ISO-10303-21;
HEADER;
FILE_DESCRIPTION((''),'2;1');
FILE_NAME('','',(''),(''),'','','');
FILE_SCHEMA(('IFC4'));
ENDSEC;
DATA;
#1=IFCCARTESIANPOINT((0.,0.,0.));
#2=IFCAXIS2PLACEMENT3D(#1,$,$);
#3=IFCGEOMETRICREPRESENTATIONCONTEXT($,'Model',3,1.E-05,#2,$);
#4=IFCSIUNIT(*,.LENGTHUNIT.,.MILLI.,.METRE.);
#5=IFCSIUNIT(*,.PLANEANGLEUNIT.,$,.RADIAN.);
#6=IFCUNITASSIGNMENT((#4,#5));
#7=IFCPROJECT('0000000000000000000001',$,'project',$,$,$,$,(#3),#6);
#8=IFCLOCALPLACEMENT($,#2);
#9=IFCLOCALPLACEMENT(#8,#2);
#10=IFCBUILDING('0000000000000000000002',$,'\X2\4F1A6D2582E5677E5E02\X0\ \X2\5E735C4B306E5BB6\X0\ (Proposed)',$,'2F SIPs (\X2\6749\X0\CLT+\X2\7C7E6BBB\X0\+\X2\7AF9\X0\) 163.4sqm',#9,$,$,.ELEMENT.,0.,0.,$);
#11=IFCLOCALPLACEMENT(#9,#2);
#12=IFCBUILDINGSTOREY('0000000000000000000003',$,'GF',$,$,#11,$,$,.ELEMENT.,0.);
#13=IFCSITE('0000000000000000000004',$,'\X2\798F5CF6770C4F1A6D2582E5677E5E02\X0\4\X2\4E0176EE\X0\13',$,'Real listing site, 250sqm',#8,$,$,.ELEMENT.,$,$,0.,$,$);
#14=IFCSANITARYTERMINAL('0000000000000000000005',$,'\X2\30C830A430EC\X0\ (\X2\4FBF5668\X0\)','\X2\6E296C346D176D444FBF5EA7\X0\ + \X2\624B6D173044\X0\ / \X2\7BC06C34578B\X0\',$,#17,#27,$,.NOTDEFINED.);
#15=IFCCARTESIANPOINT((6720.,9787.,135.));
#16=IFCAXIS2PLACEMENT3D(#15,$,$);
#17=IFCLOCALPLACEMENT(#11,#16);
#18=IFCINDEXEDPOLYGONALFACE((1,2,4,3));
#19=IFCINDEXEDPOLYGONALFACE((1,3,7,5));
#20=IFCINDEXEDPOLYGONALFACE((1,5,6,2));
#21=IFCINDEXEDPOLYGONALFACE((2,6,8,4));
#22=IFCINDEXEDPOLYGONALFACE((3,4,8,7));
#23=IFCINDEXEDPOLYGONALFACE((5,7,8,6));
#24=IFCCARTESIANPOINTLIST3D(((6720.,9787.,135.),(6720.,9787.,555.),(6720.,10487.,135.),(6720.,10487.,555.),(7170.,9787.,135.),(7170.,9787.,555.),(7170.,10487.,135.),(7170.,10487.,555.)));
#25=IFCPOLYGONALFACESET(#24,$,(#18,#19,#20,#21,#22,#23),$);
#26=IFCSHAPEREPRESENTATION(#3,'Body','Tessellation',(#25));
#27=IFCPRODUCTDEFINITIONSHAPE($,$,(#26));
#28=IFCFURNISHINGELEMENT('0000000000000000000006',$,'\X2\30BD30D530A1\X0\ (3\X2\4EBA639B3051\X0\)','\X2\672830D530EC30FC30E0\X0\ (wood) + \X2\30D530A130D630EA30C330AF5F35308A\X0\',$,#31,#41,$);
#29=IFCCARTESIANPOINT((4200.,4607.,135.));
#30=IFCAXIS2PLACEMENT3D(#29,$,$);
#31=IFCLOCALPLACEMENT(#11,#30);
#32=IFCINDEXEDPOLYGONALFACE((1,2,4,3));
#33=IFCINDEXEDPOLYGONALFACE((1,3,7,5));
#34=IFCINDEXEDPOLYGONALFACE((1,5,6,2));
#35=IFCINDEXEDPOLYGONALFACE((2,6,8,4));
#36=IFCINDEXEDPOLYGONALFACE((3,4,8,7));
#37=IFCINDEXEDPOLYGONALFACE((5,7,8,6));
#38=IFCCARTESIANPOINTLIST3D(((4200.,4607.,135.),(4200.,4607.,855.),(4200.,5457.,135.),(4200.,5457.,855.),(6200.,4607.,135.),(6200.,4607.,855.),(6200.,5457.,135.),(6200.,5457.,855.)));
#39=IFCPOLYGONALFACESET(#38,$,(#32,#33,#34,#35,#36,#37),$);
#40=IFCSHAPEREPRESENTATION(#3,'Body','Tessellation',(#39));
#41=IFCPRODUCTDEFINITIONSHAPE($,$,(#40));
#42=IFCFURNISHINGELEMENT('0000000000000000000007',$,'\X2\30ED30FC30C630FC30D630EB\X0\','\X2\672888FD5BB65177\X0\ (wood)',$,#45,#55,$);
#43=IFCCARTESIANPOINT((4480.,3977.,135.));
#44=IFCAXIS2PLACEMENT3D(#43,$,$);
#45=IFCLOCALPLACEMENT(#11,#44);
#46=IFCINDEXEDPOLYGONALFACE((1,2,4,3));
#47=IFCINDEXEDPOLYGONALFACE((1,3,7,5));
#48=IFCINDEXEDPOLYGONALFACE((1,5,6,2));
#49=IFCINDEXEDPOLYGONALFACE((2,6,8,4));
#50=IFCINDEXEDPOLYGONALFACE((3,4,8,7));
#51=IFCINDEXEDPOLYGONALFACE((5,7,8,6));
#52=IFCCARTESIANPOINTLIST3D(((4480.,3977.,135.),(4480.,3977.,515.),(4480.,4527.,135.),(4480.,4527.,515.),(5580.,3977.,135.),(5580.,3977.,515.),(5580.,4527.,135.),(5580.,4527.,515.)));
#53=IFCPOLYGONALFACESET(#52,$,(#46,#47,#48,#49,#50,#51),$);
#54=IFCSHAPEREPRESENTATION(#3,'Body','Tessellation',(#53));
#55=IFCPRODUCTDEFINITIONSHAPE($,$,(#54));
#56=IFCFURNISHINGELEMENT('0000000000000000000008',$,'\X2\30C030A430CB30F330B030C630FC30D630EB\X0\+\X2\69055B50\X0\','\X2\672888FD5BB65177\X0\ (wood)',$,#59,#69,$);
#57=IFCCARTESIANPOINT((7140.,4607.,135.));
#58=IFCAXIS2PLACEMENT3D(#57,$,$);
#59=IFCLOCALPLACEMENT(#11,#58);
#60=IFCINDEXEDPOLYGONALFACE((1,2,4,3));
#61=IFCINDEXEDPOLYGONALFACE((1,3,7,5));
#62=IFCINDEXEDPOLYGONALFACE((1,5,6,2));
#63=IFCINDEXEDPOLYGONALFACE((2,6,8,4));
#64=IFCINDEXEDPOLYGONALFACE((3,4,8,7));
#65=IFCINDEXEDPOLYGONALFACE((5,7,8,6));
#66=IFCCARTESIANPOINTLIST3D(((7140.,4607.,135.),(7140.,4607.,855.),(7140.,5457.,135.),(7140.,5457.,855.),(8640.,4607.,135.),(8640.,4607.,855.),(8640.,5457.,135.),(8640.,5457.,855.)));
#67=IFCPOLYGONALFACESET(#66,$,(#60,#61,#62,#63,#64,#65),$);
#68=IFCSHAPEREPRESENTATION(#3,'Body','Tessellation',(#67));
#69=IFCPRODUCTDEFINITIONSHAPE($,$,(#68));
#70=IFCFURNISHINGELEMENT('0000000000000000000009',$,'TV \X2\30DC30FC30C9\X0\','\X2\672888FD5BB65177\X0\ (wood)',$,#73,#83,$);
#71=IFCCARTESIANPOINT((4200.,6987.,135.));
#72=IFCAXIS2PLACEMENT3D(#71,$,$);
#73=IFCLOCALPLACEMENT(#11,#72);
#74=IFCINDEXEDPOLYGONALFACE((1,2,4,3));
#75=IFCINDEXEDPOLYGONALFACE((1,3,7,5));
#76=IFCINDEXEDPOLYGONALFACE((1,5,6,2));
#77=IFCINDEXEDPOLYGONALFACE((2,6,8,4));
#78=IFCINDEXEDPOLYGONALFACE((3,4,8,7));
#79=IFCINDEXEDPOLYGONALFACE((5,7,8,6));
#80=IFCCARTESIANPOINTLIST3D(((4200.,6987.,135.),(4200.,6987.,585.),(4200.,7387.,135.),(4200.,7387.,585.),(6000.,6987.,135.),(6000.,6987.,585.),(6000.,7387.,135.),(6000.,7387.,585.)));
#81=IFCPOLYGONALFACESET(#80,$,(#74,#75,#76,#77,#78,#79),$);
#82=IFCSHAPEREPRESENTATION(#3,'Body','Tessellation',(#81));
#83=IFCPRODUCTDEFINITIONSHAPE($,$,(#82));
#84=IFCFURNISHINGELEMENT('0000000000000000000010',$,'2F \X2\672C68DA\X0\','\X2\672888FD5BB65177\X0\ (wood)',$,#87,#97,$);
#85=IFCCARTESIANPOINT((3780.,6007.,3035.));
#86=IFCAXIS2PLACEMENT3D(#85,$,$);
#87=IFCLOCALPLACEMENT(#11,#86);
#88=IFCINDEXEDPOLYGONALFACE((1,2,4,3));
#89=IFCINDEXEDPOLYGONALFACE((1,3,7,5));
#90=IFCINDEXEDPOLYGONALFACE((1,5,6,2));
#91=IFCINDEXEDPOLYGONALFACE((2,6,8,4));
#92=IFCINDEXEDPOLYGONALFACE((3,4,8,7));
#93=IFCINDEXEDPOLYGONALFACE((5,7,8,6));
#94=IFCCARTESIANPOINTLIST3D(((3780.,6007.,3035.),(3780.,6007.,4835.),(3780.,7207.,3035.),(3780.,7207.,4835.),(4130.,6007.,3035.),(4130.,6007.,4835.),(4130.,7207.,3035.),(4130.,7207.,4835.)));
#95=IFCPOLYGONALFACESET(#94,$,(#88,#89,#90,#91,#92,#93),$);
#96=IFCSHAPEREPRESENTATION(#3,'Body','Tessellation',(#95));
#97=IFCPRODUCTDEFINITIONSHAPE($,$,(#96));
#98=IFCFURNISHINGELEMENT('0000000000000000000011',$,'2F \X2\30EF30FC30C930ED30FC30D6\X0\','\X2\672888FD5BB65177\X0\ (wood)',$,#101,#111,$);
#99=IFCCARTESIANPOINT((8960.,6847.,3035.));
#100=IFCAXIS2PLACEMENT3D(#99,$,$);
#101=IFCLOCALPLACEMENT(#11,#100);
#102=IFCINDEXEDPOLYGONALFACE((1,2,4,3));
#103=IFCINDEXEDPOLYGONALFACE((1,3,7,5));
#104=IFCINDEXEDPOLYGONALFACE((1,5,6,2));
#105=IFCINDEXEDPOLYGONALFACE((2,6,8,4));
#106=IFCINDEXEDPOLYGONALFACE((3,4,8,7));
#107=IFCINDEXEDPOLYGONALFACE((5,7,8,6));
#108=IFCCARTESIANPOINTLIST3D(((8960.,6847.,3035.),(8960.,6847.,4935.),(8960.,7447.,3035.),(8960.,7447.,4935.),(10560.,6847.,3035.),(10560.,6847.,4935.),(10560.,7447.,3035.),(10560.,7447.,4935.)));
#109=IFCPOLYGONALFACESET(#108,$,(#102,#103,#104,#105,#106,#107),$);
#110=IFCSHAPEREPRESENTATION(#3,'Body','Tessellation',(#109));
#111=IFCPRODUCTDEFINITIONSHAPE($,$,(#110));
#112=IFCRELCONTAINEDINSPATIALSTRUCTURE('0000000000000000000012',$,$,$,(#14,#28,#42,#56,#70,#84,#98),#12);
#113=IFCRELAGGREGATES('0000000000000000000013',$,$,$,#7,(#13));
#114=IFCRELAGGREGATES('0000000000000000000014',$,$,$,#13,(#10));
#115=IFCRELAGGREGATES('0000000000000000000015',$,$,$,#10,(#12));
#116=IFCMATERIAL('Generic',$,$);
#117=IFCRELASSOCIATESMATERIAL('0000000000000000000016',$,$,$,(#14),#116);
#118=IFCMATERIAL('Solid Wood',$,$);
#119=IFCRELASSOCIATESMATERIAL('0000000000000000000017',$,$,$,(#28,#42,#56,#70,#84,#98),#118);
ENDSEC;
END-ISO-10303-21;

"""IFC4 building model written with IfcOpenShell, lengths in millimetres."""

from ifc_helpers import new_model, si_unit, frame, frame_2d, origin, place, context, project, spatial, rectangle, extrude, material, element, save


model = new_model("IFC4")

# Units and contexts
model_context = context("Model", 3, precision=1e-05, world=origin())
ifc_project = project(units=[si_unit("LENGTHUNIT", "METRE", prefix="MILLI"), si_unit("PLANEANGLEUNIT", "RADIAN")], contexts=[model_context])

# Site, building, storey
site_placement = place(None, origin())
site = spatial("IfcSite", under=ifc_project, at=site_placement, Name="福島県会津若松市4丁目13", ObjectType="Real listing site, 250sqm", CompositionType="ELEMENT", RefElevation=0.0)
building_placement = place(site_placement, origin())
building = spatial("IfcBuilding", under=site, at=building_placement, Name="会津若松市 平屋の家 (Proposed)", ObjectType="2F SIPs (杉CLT+籾殻+竹) 163.4sqm", CompositionType="ELEMENT", ElevationOfRefHeight=0.0, ElevationOfTerrain=0.0)
storey_placement = place(building_placement, origin())
storey = spatial("IfcBuildingStorey", under=building, at=storey_placement, Name="GF", CompositionType="ELEMENT", Elevation=0.0)

# Shared definitions
ifc_material_1 = material(Name="Generic")

# Shared definitions
ifc_material_2 = material(Name="Solid Wood")

# Sanitary terminal
sanitary_terminal_1_placement = place(storey_placement, frame((6720.0, 9787.0, 135.0)))
element("IfcSanitaryTerminal", 1, at=sanitary_terminal_1_placement, inside=storey, material=ifc_material_1, Name="トイレ (便器)", Description="温水洗浄便座 + 手洗い / 節水型", PredefinedType="NOTDEFINED", context=model_context, shape_type="SweptSolid", body=[
    extrude(rectangle(XDim=450.0, YDim=700.0, at=frame_2d((225.0, 350.0))), frame((6720.0, 9787.0, 135.0)), (0.0, 0.0, 1.0), 420.0),
])

# Furnishing elements
furnishing_1_placement = place(storey_placement, frame((4200.0, 4607.0, 135.0)))
element("IfcFurnishingElement", 2, at=furnishing_1_placement, inside=storey, material=ifc_material_2, Name="ソファ (3人掛け)", Description="木フレーム (wood) + ファブリック張り", context=model_context, shape_type="SweptSolid", body=[
    extrude(rectangle(XDim=2000.0, YDim=850.0, at=frame_2d((1000.0, 425.0))), frame((4200.0, 4607.0, 135.0)), (0.0, 0.0, 1.0), 720.0),
])
furnishing_2_placement = place(storey_placement, frame((4480.0, 3977.0, 135.0)))
element("IfcFurnishingElement", 3, at=furnishing_2_placement, inside=storey, material=ifc_material_2, Name="ローテーブル", Description="木製家具 (wood)", context=model_context, shape_type="SweptSolid", body=[
    extrude(rectangle(XDim=1100.0, YDim=550.0, at=frame_2d((550.0, 275.0))), frame((4480.0, 3977.0, 135.0)), (0.0, 0.0, 1.0), 380.0),
])
furnishing_3_placement = place(storey_placement, frame((7140.0, 4607.0, 135.0)))
element("IfcFurnishingElement", 4, at=furnishing_3_placement, inside=storey, material=ifc_material_2, Name="ダイニングテーブル+椅子", Description="木製家具 (wood)", context=model_context, shape_type="SweptSolid", body=[
    extrude(rectangle(XDim=1500.0, YDim=850.0, at=frame_2d((750.0, 425.0))), frame((7140.0, 4607.0, 135.0)), (0.0, 0.0, 1.0), 720.0),
])
furnishing_4_placement = place(storey_placement, frame((4200.0, 6987.0, 135.0)))
element("IfcFurnishingElement", 5, at=furnishing_4_placement, inside=storey, material=ifc_material_2, Name="TV ボード", Description="木製家具 (wood)", context=model_context, shape_type="SweptSolid", body=[
    extrude(rectangle(XDim=1800.0, YDim=400.0, at=frame_2d((900.0, 200.0))), frame((4200.0, 6987.0, 135.0)), (0.0, 0.0, 1.0), 450.0),
])
furnishing_5_placement = place(storey_placement, frame((3780.0, 6007.0, 3035.0)))
element("IfcFurnishingElement", 6, at=furnishing_5_placement, inside=storey, material=ifc_material_2, Name="2F 本棚", Description="木製家具 (wood)", context=model_context, shape_type="SweptSolid", body=[
    extrude(rectangle(XDim=350.0, YDim=1200.0, at=frame_2d((175.0, 600.0))), frame((3780.0, 6007.0, 3035.0)), (0.0, 0.0, 1.0), 1800.0),
])
furnishing_6_placement = place(storey_placement, frame((8960.0, 6847.0, 3035.0)))
element("IfcFurnishingElement", 7, at=furnishing_6_placement, inside=storey, material=ifc_material_2, Name="2F ワードローブ", Description="木製家具 (wood)", context=model_context, shape_type="SweptSolid", body=[
    extrude(rectangle(XDim=1600.0, YDim=600.0, at=frame_2d((800.0, 300.0))), frame((8960.0, 6847.0, 3035.0)), (0.0, 0.0, 1.0), 1900.0),
])

save(model, "model.ifc")
